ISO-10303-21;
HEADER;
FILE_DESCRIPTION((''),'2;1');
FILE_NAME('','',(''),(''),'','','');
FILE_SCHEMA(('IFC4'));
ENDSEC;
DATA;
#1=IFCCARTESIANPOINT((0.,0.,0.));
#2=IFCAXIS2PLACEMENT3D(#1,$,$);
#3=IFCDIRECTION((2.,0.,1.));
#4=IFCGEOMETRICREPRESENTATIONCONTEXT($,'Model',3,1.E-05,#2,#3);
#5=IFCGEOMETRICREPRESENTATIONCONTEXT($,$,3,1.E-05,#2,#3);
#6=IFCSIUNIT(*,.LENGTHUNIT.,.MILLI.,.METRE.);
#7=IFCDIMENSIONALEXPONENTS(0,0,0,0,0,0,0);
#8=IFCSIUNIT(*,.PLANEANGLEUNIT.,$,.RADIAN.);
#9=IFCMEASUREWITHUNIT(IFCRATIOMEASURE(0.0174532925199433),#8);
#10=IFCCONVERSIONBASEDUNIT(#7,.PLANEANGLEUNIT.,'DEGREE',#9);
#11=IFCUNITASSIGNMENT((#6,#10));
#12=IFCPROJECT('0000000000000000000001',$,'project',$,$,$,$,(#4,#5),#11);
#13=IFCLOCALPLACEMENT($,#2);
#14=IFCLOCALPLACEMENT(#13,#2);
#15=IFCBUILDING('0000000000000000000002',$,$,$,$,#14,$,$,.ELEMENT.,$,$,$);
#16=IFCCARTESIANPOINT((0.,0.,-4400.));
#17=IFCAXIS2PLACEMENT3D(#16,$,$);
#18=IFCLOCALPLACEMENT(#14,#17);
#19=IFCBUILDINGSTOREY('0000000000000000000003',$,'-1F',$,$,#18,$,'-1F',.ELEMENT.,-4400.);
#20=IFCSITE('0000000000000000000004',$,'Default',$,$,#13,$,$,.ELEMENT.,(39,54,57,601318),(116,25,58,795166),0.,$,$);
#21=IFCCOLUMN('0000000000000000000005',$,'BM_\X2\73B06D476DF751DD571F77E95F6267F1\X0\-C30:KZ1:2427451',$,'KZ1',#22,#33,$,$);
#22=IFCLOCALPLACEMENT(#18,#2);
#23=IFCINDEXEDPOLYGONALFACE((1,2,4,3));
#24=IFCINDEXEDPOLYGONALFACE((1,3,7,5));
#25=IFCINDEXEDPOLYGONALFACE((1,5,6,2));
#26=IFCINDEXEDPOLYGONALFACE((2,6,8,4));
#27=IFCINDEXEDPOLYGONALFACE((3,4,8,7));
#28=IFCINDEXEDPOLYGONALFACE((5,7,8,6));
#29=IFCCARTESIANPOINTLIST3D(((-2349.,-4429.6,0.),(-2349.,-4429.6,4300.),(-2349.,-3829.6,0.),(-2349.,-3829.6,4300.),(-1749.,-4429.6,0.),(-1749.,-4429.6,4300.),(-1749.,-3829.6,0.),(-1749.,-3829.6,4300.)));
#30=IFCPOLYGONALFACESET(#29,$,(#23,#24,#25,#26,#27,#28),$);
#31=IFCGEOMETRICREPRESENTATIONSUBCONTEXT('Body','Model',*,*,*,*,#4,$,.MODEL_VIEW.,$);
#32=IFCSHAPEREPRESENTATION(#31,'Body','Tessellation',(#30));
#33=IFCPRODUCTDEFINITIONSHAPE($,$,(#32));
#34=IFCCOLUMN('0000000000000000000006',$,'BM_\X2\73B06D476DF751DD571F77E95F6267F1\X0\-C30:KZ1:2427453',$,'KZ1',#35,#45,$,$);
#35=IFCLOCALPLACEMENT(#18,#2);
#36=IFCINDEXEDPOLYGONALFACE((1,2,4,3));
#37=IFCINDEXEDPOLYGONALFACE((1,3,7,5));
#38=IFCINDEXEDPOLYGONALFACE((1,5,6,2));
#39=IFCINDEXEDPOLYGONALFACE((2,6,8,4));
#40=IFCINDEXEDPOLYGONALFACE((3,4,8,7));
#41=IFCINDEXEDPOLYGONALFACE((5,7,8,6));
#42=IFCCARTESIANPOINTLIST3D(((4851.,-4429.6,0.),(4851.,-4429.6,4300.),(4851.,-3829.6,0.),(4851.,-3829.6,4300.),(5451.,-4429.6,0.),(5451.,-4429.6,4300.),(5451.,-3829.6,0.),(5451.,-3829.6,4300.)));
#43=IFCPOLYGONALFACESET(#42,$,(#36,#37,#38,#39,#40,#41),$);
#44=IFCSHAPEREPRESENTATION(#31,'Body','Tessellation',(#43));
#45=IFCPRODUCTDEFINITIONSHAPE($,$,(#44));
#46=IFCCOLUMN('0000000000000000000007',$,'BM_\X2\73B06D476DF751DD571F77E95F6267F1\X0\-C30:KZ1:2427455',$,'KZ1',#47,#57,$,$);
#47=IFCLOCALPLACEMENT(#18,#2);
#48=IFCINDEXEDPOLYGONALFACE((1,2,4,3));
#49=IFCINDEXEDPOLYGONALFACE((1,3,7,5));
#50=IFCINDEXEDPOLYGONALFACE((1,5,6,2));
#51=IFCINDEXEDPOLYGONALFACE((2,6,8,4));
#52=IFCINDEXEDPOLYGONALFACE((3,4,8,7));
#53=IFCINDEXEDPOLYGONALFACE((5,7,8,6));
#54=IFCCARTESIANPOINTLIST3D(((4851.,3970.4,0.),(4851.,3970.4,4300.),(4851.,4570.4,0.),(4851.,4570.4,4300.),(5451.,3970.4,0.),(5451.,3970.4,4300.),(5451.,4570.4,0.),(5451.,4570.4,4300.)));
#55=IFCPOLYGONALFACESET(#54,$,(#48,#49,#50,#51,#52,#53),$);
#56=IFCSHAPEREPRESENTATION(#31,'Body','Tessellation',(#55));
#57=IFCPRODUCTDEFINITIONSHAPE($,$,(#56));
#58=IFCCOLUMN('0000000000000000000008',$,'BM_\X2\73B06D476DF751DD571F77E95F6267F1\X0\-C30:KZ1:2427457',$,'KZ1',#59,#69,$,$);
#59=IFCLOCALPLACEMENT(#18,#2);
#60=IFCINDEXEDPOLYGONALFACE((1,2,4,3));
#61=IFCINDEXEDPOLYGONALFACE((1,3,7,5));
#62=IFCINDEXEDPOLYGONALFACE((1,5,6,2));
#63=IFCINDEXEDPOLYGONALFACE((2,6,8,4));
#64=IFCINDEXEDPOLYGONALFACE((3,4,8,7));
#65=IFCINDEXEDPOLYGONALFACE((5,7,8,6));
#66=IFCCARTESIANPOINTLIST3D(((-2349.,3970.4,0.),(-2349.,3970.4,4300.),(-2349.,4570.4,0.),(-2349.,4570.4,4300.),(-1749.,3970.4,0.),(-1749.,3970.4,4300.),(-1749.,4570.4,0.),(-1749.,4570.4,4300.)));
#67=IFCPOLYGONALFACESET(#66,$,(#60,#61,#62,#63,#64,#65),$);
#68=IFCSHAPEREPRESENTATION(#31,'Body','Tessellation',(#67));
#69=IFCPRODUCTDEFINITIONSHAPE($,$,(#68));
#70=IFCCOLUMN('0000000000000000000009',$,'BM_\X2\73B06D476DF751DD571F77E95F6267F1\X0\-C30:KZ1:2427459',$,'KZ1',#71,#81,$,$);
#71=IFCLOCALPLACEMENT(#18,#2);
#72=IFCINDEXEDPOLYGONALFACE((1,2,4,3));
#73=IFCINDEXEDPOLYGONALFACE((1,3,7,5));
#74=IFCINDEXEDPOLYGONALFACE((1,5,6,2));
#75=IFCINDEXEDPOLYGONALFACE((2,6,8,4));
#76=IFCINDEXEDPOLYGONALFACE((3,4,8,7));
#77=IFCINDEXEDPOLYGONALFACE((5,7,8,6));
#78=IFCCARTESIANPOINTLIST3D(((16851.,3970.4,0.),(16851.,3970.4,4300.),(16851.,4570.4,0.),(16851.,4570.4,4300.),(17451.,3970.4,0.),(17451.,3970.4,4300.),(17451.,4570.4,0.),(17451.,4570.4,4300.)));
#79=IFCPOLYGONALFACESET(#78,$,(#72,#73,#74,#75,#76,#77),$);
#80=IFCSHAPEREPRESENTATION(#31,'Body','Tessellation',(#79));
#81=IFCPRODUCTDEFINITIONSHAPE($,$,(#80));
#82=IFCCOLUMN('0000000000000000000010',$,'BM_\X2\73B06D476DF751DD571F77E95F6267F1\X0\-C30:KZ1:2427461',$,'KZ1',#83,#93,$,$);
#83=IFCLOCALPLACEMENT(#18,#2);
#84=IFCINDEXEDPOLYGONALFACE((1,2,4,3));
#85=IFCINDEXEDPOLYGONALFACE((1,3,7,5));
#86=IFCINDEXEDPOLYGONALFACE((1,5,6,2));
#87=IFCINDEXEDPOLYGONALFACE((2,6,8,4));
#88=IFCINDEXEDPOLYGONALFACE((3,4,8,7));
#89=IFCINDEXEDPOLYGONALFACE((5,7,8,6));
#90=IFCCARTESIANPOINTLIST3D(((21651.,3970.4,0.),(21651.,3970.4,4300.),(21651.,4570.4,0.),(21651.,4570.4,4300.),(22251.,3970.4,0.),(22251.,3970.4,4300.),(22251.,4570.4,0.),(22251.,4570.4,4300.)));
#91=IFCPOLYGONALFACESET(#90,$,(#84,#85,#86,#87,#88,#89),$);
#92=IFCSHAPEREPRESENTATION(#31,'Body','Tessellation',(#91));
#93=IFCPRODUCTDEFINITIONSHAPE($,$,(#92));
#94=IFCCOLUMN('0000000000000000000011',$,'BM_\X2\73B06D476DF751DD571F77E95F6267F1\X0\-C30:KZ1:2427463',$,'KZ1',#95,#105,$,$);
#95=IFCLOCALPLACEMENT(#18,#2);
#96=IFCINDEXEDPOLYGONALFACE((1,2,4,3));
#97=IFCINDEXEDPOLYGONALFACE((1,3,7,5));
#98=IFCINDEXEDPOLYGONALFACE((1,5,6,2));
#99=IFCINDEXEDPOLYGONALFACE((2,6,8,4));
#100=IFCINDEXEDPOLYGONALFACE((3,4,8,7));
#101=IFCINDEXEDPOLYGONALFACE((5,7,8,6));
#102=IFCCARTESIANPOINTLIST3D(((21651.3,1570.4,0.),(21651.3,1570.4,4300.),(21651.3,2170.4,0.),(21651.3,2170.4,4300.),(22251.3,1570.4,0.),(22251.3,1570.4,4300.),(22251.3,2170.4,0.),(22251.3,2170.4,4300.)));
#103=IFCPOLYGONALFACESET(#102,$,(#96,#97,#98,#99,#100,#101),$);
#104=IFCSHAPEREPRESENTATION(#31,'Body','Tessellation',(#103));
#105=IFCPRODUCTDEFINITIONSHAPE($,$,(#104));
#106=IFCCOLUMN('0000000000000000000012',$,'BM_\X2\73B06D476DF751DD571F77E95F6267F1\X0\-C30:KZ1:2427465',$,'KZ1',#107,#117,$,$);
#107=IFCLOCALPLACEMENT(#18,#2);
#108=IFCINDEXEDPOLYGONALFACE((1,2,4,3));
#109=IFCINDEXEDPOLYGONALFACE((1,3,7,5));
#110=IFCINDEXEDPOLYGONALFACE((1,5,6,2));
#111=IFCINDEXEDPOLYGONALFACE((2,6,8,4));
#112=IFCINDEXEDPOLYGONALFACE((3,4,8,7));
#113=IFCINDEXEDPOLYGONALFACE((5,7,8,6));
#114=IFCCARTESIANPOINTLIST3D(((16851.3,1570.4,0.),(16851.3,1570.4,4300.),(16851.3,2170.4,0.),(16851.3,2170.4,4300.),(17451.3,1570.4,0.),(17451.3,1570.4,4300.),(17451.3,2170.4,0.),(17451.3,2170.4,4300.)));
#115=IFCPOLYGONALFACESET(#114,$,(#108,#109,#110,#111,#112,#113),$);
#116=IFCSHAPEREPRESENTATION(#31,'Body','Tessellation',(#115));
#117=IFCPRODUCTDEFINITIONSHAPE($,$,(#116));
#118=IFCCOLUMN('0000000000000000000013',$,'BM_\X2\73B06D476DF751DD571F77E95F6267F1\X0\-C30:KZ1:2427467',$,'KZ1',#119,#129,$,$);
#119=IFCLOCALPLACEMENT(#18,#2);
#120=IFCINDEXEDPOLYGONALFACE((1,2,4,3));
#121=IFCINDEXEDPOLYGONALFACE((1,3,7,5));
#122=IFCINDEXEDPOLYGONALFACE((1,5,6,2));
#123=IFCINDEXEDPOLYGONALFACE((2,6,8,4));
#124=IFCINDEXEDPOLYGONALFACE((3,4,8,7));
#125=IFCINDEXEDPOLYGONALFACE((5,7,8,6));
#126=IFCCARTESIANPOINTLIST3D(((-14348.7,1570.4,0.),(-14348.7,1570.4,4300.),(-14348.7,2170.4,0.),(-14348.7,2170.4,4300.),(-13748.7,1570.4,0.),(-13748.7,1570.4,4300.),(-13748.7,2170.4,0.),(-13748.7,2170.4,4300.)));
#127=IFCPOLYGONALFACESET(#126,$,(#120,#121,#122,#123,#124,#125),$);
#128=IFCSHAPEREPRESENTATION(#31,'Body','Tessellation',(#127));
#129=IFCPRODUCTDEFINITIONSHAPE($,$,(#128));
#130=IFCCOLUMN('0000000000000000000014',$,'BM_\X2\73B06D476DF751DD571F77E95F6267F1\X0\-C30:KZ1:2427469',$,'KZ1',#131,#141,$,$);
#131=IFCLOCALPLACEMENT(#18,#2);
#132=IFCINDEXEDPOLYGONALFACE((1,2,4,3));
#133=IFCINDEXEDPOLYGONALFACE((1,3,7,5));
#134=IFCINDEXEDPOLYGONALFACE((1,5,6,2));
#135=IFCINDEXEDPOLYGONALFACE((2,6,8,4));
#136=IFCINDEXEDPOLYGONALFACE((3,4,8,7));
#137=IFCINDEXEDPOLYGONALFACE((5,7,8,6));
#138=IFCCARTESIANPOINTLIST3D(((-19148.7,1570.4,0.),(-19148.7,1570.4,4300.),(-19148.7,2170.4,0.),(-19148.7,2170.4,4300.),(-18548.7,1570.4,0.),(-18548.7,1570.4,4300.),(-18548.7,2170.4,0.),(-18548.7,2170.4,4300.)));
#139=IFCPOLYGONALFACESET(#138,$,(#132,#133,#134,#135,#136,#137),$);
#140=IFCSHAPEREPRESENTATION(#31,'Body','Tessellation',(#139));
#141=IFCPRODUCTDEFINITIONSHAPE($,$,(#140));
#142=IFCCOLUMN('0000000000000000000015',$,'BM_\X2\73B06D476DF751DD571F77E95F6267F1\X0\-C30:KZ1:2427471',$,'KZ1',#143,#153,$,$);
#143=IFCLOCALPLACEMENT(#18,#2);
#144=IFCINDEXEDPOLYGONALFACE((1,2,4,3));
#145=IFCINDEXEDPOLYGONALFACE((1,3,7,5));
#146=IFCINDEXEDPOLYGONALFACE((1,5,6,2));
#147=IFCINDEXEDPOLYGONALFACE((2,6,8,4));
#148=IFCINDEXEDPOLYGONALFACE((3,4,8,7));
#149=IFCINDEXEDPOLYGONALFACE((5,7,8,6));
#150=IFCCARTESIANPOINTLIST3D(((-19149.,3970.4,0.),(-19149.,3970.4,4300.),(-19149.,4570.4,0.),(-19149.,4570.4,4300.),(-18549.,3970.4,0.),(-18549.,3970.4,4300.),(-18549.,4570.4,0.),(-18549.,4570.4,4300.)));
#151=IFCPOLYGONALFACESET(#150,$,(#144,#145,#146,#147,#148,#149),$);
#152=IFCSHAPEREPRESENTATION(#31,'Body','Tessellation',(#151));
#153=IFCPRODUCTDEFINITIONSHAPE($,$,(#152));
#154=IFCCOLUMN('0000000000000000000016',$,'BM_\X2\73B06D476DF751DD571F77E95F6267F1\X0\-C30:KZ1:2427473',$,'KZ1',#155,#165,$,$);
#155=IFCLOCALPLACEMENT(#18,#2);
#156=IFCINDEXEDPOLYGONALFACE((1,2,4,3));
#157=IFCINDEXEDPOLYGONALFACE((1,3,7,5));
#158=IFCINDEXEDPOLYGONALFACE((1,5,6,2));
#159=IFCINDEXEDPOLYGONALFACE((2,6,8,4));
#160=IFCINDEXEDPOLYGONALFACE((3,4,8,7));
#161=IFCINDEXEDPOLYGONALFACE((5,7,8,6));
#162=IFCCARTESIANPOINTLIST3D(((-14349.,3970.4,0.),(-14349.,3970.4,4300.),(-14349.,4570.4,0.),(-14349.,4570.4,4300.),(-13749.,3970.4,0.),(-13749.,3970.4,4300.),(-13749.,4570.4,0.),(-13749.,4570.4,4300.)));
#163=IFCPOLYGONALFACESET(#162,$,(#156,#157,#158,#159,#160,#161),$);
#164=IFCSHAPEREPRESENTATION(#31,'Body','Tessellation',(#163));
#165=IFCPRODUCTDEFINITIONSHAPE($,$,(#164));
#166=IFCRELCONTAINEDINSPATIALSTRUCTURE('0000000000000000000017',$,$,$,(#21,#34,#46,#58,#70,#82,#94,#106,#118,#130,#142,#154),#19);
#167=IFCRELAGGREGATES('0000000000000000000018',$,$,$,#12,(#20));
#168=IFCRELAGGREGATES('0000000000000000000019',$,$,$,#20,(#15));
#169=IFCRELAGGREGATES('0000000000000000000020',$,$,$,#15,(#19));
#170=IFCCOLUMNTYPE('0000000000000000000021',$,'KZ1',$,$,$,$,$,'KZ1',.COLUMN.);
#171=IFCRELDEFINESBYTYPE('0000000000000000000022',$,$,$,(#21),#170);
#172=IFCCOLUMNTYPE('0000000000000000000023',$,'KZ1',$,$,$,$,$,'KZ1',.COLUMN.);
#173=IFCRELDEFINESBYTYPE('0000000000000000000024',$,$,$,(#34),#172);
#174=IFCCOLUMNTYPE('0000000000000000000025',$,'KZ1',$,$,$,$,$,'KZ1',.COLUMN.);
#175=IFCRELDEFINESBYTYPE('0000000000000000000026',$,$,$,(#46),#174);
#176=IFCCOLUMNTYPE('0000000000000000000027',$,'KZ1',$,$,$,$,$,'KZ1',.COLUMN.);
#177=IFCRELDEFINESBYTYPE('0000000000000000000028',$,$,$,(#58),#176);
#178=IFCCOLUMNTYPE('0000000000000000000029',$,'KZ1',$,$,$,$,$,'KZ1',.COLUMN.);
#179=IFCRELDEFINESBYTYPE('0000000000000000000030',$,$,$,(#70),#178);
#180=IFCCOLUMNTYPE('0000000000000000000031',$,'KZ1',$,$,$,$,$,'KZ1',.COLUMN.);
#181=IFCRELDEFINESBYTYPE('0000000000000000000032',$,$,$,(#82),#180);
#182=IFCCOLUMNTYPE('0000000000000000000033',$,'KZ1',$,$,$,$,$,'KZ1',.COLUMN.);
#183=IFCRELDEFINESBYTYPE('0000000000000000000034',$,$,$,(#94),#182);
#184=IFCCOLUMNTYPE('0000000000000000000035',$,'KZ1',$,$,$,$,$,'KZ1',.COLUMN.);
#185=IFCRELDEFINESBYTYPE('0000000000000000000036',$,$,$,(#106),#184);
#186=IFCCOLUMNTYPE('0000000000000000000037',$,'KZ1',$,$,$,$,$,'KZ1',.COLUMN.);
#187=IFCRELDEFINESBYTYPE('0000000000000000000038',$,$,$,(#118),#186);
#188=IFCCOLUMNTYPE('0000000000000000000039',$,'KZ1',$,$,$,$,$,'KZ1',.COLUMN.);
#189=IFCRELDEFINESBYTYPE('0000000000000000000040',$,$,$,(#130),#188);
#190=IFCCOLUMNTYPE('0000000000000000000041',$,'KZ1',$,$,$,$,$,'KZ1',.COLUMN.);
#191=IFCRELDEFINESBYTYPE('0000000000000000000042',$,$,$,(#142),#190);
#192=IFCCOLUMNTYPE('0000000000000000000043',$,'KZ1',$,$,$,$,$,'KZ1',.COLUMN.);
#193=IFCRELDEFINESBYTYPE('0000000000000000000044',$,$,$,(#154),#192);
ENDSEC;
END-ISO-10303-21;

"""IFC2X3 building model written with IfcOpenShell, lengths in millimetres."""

from ifc_helpers import new_model, entity, si_unit, converted_unit, direction, frame, frame_2d, origin, place, context, subcontext, project, spatial, rectangle, extrude, source, transform, mapped, type_object, type_shapes, element, save


model = new_model("IFC2X3")

# Units and contexts
model_context = context("Model", 3, precision=1e-05, world=origin(), true_north=direction((2.0, 0.0, 1.0)))
context_of_model = context(None, 3, precision=1e-05, world=origin(), true_north=direction((2.0, 0.0, 1.0)))
body_context = subcontext(model_context, "Body", "Model", "MODEL_VIEW")
ifc_project = project(units=[si_unit("LENGTHUNIT", "METRE", prefix="MILLI"), converted_unit("PLANEANGLEUNIT", "DEGREE", entity("IfcRatioMeasure", 0.0174532925199433), si_unit("PLANEANGLEUNIT", "RADIAN"), dimensions=[0, 0, 0, 0, 0, 0, 0])], contexts=[model_context, context_of_model])

# Site, building, storey
site_placement = place(None, origin())
site = spatial("IfcSite", under=ifc_project, at=site_placement, Name="Default", CompositionType="ELEMENT", RefLatitude=(39, 54, 57, 601318), RefLongitude=(116, 25, 58, 795166), RefElevation=0.0)
building_placement = place(site_placement, origin())
building = spatial("IfcBuilding", under=site, at=building_placement, CompositionType="ELEMENT")
storey_placement = place(building_placement, frame((0.0, 0.0, -4400.0)))
storey = spatial("IfcBuildingStorey", under=building, at=storey_placement, Name="-1F", LongName="-1F", CompositionType="ELEMENT", Elevation=-4400.0)

# Columns
column_type_1 = type_object("IfcColumnType", Name="KZ1", ElementType="KZ1", PredefinedType="COLUMN")
shared_shape_1 = source(origin(), body_context, "Body", "SweptSolid", [
    extrude(rectangle(XDim=600.0, YDim=600.0, at=frame_2d((-2049.0, -4129.6), x_axis=(0.0, -1.0))), origin(), (0.0, 0.0, 1.0), 4300.0),
])
type_shapes(column_type_1, [shared_shape_1])
column_1_placement = place(storey_placement, origin())
element("IfcColumn", 1, at=column_1_placement, inside=storey, type_object=column_type_1, Name="BM_现浇混凝土矩形柱-C30:KZ1:2427451", ObjectType="KZ1", context=body_context, shape_type="MappedRepresentation", body=[
    mapped(shared_shape_1, transform((0.0, 0.0, 0.0), scale=1.0)),
])
column_type_2 = type_object("IfcColumnType", Name="KZ1", ElementType="KZ1", PredefinedType="COLUMN")
shared_shape_2 = source(origin(), body_context, "Body", "SweptSolid", [
    extrude(rectangle(XDim=600.0, YDim=600.0, at=frame_2d((5151.0, -4129.6), x_axis=(0.0, -1.0))), origin(), (0.0, 0.0, 1.0), 4300.0),
])
type_shapes(column_type_2, [shared_shape_2])
column_2_placement = place(storey_placement, origin())
element("IfcColumn", 2, at=column_2_placement, inside=storey, type_object=column_type_2, Name="BM_现浇混凝土矩形柱-C30:KZ1:2427453", ObjectType="KZ1", context=body_context, shape_type="MappedRepresentation", body=[
    mapped(shared_shape_2, transform((0.0, 0.0, 0.0), scale=1.0)),
])
column_type_3 = type_object("IfcColumnType", Name="KZ1", ElementType="KZ1", PredefinedType="COLUMN")
shared_shape_3 = source(origin(), body_context, "Body", "SweptSolid", [
    extrude(rectangle(XDim=600.0, YDim=600.0, at=frame_2d((5151.0, 4270.4), x_axis=(0.0, -1.0))), origin(), (0.0, 0.0, 1.0), 4300.0),
])
type_shapes(column_type_3, [shared_shape_3])
column_3_placement = place(storey_placement, origin())
element("IfcColumn", 3, at=column_3_placement, inside=storey, type_object=column_type_3, Name="BM_现浇混凝土矩形柱-C30:KZ1:2427455", ObjectType="KZ1", context=body_context, shape_type="MappedRepresentation", body=[
    mapped(shared_shape_3, transform((0.0, 0.0, 0.0), scale=1.0)),
])
column_type_4 = type_object("IfcColumnType", Name="KZ1", ElementType="KZ1", PredefinedType="COLUMN")
shared_shape_4 = source(origin(), body_context, "Body", "SweptSolid", [
    extrude(rectangle(XDim=600.0, YDim=600.0, at=frame_2d((-2049.0, 4270.4), x_axis=(0.0, -1.0))), origin(), (0.0, 0.0, 1.0), 4300.0),
])
type_shapes(column_type_4, [shared_shape_4])
column_4_placement = place(storey_placement, origin())
element("IfcColumn", 4, at=column_4_placement, inside=storey, type_object=column_type_4, Name="BM_现浇混凝土矩形柱-C30:KZ1:2427457", ObjectType="KZ1", context=body_context, shape_type="MappedRepresentation", body=[
    mapped(shared_shape_4, transform((0.0, 0.0, 0.0), scale=1.0)),
])
column_type_5 = type_object("IfcColumnType", Name="KZ1", ElementType="KZ1", PredefinedType="COLUMN")
shared_shape_5 = source(origin(), body_context, "Body", "SweptSolid", [
    extrude(rectangle(XDim=600.0, YDim=600.0, at=frame_2d((17151.0, 4270.4), x_axis=(0.0, -1.0))), origin(), (0.0, 0.0, 1.0), 4300.0),
])
type_shapes(column_type_5, [shared_shape_5])
column_5_placement = place(storey_placement, origin())
element("IfcColumn", 5, at=column_5_placement, inside=storey, type_object=column_type_5, Name="BM_现浇混凝土矩形柱-C30:KZ1:2427459", ObjectType="KZ1", context=body_context, shape_type="MappedRepresentation", body=[
    mapped(shared_shape_5, transform((0.0, 0.0, 0.0), scale=1.0)),
])
column_type_6 = type_object("IfcColumnType", Name="KZ1", ElementType="KZ1", PredefinedType="COLUMN")
shared_shape_6 = source(origin(), body_context, "Body", "SweptSolid", [
    extrude(rectangle(XDim=600.0, YDim=600.0, at=frame_2d((21951.0, 4270.4), x_axis=(0.0, -1.0))), origin(), (0.0, 0.0, 1.0), 4300.0),
])
type_shapes(column_type_6, [shared_shape_6])
column_6_placement = place(storey_placement, origin())
element("IfcColumn", 6, at=column_6_placement, inside=storey, type_object=column_type_6, Name="BM_现浇混凝土矩形柱-C30:KZ1:2427461", ObjectType="KZ1", context=body_context, shape_type="MappedRepresentation", body=[
    mapped(shared_shape_6, transform((0.0, 0.0, 0.0), scale=1.0)),
])
column_type_7 = type_object("IfcColumnType", Name="KZ1", ElementType="KZ1", PredefinedType="COLUMN")
shared_shape_7 = source(origin(), body_context, "Body", "SweptSolid", [
    extrude(rectangle(XDim=600.0, YDim=600.0, at=frame_2d((21951.3, 1870.4), x_axis=(0.0, -1.0))), origin(), (0.0, 0.0, 1.0), 4300.0),
])
type_shapes(column_type_7, [shared_shape_7])
column_7_placement = place(storey_placement, origin())
element("IfcColumn", 7, at=column_7_placement, inside=storey, type_object=column_type_7, Name="BM_现浇混凝土矩形柱-C30:KZ1:2427463", ObjectType="KZ1", context=body_context, shape_type="MappedRepresentation", body=[
    mapped(shared_shape_7, transform((0.0, 0.0, 0.0), scale=1.0)),
])
column_type_8 = type_object("IfcColumnType", Name="KZ1", ElementType="KZ1", PredefinedType="COLUMN")
shared_shape_8 = source(origin(), body_context, "Body", "SweptSolid", [
    extrude(rectangle(XDim=600.0, YDim=600.0, at=frame_2d((17151.3, 1870.4), x_axis=(0.0, -1.0))), origin(), (0.0, 0.0, 1.0), 4300.0),
])
type_shapes(column_type_8, [shared_shape_8])
column_8_placement = place(storey_placement, origin())
element("IfcColumn", 8, at=column_8_placement, inside=storey, type_object=column_type_8, Name="BM_现浇混凝土矩形柱-C30:KZ1:2427465", ObjectType="KZ1", context=body_context, shape_type="MappedRepresentation", body=[
    mapped(shared_shape_8, transform((0.0, 0.0, 0.0), scale=1.0)),
])
column_type_9 = type_object("IfcColumnType", Name="KZ1", ElementType="KZ1", PredefinedType="COLUMN")
shared_shape_9 = source(origin(), body_context, "Body", "SweptSolid", [
    extrude(rectangle(XDim=600.0, YDim=600.0, at=frame_2d((-14048.7, 1870.4), x_axis=(0.0, -1.0))), origin(), (0.0, 0.0, 1.0), 4300.0),
])
type_shapes(column_type_9, [shared_shape_9])
column_9_placement = place(storey_placement, origin())
element("IfcColumn", 9, at=column_9_placement, inside=storey, type_object=column_type_9, Name="BM_现浇混凝土矩形柱-C30:KZ1:2427467", ObjectType="KZ1", context=body_context, shape_type="MappedRepresentation", body=[
    mapped(shared_shape_9, transform((0.0, 0.0, 0.0), scale=1.0)),
])
column_type_10 = type_object("IfcColumnType", Name="KZ1", ElementType="KZ1", PredefinedType="COLUMN")
shared_shape_10 = source(origin(), body_context, "Body", "SweptSolid", [
    extrude(rectangle(XDim=600.0, YDim=600.0, at=frame_2d((-18848.7, 1870.4), x_axis=(0.0, -1.0))), origin(), (0.0, 0.0, 1.0), 4300.0),
])
type_shapes(column_type_10, [shared_shape_10])
column_10_placement = place(storey_placement, origin())
element("IfcColumn", 10, at=column_10_placement, inside=storey, type_object=column_type_10, Name="BM_现浇混凝土矩形柱-C30:KZ1:2427469", ObjectType="KZ1", context=body_context, shape_type="MappedRepresentation", body=[
    mapped(shared_shape_10, transform((0.0, 0.0, 0.0), scale=1.0)),
])
column_type_11 = type_object("IfcColumnType", Name="KZ1", ElementType="KZ1", PredefinedType="COLUMN")
shared_shape_11 = source(origin(), body_context, "Body", "SweptSolid", [
    extrude(rectangle(XDim=600.0, YDim=600.0, at=frame_2d((-18849.0, 4270.4), x_axis=(0.0, -1.0))), origin(), (0.0, 0.0, 1.0), 4300.0),
])
type_shapes(column_type_11, [shared_shape_11])
column_11_placement = place(storey_placement, origin())
element("IfcColumn", 11, at=column_11_placement, inside=storey, type_object=column_type_11, Name="BM_现浇混凝土矩形柱-C30:KZ1:2427471", ObjectType="KZ1", context=body_context, shape_type="MappedRepresentation", body=[
    mapped(shared_shape_11, transform((0.0, 0.0, 0.0), scale=1.0)),
])
column_type_12 = type_object("IfcColumnType", Name="KZ1", ElementType="KZ1", PredefinedType="COLUMN")
shared_shape_12 = source(origin(), body_context, "Body", "SweptSolid", [
    extrude(rectangle(XDim=600.0, YDim=600.0, at=frame_2d((-14049.0, 4270.4), x_axis=(0.0, -1.0))), origin(), (0.0, 0.0, 1.0), 4300.0),
])
type_shapes(column_type_12, [shared_shape_12])
column_12_placement = place(storey_placement, origin())
element("IfcColumn", 12, at=column_12_placement, inside=storey, type_object=column_type_12, Name="BM_现浇混凝土矩形柱-C30:KZ1:2427473", ObjectType="KZ1", context=body_context, shape_type="MappedRepresentation", body=[
    mapped(shared_shape_12, transform((0.0, 0.0, 0.0), scale=1.0)),
])

save(model, "model.ifc")
